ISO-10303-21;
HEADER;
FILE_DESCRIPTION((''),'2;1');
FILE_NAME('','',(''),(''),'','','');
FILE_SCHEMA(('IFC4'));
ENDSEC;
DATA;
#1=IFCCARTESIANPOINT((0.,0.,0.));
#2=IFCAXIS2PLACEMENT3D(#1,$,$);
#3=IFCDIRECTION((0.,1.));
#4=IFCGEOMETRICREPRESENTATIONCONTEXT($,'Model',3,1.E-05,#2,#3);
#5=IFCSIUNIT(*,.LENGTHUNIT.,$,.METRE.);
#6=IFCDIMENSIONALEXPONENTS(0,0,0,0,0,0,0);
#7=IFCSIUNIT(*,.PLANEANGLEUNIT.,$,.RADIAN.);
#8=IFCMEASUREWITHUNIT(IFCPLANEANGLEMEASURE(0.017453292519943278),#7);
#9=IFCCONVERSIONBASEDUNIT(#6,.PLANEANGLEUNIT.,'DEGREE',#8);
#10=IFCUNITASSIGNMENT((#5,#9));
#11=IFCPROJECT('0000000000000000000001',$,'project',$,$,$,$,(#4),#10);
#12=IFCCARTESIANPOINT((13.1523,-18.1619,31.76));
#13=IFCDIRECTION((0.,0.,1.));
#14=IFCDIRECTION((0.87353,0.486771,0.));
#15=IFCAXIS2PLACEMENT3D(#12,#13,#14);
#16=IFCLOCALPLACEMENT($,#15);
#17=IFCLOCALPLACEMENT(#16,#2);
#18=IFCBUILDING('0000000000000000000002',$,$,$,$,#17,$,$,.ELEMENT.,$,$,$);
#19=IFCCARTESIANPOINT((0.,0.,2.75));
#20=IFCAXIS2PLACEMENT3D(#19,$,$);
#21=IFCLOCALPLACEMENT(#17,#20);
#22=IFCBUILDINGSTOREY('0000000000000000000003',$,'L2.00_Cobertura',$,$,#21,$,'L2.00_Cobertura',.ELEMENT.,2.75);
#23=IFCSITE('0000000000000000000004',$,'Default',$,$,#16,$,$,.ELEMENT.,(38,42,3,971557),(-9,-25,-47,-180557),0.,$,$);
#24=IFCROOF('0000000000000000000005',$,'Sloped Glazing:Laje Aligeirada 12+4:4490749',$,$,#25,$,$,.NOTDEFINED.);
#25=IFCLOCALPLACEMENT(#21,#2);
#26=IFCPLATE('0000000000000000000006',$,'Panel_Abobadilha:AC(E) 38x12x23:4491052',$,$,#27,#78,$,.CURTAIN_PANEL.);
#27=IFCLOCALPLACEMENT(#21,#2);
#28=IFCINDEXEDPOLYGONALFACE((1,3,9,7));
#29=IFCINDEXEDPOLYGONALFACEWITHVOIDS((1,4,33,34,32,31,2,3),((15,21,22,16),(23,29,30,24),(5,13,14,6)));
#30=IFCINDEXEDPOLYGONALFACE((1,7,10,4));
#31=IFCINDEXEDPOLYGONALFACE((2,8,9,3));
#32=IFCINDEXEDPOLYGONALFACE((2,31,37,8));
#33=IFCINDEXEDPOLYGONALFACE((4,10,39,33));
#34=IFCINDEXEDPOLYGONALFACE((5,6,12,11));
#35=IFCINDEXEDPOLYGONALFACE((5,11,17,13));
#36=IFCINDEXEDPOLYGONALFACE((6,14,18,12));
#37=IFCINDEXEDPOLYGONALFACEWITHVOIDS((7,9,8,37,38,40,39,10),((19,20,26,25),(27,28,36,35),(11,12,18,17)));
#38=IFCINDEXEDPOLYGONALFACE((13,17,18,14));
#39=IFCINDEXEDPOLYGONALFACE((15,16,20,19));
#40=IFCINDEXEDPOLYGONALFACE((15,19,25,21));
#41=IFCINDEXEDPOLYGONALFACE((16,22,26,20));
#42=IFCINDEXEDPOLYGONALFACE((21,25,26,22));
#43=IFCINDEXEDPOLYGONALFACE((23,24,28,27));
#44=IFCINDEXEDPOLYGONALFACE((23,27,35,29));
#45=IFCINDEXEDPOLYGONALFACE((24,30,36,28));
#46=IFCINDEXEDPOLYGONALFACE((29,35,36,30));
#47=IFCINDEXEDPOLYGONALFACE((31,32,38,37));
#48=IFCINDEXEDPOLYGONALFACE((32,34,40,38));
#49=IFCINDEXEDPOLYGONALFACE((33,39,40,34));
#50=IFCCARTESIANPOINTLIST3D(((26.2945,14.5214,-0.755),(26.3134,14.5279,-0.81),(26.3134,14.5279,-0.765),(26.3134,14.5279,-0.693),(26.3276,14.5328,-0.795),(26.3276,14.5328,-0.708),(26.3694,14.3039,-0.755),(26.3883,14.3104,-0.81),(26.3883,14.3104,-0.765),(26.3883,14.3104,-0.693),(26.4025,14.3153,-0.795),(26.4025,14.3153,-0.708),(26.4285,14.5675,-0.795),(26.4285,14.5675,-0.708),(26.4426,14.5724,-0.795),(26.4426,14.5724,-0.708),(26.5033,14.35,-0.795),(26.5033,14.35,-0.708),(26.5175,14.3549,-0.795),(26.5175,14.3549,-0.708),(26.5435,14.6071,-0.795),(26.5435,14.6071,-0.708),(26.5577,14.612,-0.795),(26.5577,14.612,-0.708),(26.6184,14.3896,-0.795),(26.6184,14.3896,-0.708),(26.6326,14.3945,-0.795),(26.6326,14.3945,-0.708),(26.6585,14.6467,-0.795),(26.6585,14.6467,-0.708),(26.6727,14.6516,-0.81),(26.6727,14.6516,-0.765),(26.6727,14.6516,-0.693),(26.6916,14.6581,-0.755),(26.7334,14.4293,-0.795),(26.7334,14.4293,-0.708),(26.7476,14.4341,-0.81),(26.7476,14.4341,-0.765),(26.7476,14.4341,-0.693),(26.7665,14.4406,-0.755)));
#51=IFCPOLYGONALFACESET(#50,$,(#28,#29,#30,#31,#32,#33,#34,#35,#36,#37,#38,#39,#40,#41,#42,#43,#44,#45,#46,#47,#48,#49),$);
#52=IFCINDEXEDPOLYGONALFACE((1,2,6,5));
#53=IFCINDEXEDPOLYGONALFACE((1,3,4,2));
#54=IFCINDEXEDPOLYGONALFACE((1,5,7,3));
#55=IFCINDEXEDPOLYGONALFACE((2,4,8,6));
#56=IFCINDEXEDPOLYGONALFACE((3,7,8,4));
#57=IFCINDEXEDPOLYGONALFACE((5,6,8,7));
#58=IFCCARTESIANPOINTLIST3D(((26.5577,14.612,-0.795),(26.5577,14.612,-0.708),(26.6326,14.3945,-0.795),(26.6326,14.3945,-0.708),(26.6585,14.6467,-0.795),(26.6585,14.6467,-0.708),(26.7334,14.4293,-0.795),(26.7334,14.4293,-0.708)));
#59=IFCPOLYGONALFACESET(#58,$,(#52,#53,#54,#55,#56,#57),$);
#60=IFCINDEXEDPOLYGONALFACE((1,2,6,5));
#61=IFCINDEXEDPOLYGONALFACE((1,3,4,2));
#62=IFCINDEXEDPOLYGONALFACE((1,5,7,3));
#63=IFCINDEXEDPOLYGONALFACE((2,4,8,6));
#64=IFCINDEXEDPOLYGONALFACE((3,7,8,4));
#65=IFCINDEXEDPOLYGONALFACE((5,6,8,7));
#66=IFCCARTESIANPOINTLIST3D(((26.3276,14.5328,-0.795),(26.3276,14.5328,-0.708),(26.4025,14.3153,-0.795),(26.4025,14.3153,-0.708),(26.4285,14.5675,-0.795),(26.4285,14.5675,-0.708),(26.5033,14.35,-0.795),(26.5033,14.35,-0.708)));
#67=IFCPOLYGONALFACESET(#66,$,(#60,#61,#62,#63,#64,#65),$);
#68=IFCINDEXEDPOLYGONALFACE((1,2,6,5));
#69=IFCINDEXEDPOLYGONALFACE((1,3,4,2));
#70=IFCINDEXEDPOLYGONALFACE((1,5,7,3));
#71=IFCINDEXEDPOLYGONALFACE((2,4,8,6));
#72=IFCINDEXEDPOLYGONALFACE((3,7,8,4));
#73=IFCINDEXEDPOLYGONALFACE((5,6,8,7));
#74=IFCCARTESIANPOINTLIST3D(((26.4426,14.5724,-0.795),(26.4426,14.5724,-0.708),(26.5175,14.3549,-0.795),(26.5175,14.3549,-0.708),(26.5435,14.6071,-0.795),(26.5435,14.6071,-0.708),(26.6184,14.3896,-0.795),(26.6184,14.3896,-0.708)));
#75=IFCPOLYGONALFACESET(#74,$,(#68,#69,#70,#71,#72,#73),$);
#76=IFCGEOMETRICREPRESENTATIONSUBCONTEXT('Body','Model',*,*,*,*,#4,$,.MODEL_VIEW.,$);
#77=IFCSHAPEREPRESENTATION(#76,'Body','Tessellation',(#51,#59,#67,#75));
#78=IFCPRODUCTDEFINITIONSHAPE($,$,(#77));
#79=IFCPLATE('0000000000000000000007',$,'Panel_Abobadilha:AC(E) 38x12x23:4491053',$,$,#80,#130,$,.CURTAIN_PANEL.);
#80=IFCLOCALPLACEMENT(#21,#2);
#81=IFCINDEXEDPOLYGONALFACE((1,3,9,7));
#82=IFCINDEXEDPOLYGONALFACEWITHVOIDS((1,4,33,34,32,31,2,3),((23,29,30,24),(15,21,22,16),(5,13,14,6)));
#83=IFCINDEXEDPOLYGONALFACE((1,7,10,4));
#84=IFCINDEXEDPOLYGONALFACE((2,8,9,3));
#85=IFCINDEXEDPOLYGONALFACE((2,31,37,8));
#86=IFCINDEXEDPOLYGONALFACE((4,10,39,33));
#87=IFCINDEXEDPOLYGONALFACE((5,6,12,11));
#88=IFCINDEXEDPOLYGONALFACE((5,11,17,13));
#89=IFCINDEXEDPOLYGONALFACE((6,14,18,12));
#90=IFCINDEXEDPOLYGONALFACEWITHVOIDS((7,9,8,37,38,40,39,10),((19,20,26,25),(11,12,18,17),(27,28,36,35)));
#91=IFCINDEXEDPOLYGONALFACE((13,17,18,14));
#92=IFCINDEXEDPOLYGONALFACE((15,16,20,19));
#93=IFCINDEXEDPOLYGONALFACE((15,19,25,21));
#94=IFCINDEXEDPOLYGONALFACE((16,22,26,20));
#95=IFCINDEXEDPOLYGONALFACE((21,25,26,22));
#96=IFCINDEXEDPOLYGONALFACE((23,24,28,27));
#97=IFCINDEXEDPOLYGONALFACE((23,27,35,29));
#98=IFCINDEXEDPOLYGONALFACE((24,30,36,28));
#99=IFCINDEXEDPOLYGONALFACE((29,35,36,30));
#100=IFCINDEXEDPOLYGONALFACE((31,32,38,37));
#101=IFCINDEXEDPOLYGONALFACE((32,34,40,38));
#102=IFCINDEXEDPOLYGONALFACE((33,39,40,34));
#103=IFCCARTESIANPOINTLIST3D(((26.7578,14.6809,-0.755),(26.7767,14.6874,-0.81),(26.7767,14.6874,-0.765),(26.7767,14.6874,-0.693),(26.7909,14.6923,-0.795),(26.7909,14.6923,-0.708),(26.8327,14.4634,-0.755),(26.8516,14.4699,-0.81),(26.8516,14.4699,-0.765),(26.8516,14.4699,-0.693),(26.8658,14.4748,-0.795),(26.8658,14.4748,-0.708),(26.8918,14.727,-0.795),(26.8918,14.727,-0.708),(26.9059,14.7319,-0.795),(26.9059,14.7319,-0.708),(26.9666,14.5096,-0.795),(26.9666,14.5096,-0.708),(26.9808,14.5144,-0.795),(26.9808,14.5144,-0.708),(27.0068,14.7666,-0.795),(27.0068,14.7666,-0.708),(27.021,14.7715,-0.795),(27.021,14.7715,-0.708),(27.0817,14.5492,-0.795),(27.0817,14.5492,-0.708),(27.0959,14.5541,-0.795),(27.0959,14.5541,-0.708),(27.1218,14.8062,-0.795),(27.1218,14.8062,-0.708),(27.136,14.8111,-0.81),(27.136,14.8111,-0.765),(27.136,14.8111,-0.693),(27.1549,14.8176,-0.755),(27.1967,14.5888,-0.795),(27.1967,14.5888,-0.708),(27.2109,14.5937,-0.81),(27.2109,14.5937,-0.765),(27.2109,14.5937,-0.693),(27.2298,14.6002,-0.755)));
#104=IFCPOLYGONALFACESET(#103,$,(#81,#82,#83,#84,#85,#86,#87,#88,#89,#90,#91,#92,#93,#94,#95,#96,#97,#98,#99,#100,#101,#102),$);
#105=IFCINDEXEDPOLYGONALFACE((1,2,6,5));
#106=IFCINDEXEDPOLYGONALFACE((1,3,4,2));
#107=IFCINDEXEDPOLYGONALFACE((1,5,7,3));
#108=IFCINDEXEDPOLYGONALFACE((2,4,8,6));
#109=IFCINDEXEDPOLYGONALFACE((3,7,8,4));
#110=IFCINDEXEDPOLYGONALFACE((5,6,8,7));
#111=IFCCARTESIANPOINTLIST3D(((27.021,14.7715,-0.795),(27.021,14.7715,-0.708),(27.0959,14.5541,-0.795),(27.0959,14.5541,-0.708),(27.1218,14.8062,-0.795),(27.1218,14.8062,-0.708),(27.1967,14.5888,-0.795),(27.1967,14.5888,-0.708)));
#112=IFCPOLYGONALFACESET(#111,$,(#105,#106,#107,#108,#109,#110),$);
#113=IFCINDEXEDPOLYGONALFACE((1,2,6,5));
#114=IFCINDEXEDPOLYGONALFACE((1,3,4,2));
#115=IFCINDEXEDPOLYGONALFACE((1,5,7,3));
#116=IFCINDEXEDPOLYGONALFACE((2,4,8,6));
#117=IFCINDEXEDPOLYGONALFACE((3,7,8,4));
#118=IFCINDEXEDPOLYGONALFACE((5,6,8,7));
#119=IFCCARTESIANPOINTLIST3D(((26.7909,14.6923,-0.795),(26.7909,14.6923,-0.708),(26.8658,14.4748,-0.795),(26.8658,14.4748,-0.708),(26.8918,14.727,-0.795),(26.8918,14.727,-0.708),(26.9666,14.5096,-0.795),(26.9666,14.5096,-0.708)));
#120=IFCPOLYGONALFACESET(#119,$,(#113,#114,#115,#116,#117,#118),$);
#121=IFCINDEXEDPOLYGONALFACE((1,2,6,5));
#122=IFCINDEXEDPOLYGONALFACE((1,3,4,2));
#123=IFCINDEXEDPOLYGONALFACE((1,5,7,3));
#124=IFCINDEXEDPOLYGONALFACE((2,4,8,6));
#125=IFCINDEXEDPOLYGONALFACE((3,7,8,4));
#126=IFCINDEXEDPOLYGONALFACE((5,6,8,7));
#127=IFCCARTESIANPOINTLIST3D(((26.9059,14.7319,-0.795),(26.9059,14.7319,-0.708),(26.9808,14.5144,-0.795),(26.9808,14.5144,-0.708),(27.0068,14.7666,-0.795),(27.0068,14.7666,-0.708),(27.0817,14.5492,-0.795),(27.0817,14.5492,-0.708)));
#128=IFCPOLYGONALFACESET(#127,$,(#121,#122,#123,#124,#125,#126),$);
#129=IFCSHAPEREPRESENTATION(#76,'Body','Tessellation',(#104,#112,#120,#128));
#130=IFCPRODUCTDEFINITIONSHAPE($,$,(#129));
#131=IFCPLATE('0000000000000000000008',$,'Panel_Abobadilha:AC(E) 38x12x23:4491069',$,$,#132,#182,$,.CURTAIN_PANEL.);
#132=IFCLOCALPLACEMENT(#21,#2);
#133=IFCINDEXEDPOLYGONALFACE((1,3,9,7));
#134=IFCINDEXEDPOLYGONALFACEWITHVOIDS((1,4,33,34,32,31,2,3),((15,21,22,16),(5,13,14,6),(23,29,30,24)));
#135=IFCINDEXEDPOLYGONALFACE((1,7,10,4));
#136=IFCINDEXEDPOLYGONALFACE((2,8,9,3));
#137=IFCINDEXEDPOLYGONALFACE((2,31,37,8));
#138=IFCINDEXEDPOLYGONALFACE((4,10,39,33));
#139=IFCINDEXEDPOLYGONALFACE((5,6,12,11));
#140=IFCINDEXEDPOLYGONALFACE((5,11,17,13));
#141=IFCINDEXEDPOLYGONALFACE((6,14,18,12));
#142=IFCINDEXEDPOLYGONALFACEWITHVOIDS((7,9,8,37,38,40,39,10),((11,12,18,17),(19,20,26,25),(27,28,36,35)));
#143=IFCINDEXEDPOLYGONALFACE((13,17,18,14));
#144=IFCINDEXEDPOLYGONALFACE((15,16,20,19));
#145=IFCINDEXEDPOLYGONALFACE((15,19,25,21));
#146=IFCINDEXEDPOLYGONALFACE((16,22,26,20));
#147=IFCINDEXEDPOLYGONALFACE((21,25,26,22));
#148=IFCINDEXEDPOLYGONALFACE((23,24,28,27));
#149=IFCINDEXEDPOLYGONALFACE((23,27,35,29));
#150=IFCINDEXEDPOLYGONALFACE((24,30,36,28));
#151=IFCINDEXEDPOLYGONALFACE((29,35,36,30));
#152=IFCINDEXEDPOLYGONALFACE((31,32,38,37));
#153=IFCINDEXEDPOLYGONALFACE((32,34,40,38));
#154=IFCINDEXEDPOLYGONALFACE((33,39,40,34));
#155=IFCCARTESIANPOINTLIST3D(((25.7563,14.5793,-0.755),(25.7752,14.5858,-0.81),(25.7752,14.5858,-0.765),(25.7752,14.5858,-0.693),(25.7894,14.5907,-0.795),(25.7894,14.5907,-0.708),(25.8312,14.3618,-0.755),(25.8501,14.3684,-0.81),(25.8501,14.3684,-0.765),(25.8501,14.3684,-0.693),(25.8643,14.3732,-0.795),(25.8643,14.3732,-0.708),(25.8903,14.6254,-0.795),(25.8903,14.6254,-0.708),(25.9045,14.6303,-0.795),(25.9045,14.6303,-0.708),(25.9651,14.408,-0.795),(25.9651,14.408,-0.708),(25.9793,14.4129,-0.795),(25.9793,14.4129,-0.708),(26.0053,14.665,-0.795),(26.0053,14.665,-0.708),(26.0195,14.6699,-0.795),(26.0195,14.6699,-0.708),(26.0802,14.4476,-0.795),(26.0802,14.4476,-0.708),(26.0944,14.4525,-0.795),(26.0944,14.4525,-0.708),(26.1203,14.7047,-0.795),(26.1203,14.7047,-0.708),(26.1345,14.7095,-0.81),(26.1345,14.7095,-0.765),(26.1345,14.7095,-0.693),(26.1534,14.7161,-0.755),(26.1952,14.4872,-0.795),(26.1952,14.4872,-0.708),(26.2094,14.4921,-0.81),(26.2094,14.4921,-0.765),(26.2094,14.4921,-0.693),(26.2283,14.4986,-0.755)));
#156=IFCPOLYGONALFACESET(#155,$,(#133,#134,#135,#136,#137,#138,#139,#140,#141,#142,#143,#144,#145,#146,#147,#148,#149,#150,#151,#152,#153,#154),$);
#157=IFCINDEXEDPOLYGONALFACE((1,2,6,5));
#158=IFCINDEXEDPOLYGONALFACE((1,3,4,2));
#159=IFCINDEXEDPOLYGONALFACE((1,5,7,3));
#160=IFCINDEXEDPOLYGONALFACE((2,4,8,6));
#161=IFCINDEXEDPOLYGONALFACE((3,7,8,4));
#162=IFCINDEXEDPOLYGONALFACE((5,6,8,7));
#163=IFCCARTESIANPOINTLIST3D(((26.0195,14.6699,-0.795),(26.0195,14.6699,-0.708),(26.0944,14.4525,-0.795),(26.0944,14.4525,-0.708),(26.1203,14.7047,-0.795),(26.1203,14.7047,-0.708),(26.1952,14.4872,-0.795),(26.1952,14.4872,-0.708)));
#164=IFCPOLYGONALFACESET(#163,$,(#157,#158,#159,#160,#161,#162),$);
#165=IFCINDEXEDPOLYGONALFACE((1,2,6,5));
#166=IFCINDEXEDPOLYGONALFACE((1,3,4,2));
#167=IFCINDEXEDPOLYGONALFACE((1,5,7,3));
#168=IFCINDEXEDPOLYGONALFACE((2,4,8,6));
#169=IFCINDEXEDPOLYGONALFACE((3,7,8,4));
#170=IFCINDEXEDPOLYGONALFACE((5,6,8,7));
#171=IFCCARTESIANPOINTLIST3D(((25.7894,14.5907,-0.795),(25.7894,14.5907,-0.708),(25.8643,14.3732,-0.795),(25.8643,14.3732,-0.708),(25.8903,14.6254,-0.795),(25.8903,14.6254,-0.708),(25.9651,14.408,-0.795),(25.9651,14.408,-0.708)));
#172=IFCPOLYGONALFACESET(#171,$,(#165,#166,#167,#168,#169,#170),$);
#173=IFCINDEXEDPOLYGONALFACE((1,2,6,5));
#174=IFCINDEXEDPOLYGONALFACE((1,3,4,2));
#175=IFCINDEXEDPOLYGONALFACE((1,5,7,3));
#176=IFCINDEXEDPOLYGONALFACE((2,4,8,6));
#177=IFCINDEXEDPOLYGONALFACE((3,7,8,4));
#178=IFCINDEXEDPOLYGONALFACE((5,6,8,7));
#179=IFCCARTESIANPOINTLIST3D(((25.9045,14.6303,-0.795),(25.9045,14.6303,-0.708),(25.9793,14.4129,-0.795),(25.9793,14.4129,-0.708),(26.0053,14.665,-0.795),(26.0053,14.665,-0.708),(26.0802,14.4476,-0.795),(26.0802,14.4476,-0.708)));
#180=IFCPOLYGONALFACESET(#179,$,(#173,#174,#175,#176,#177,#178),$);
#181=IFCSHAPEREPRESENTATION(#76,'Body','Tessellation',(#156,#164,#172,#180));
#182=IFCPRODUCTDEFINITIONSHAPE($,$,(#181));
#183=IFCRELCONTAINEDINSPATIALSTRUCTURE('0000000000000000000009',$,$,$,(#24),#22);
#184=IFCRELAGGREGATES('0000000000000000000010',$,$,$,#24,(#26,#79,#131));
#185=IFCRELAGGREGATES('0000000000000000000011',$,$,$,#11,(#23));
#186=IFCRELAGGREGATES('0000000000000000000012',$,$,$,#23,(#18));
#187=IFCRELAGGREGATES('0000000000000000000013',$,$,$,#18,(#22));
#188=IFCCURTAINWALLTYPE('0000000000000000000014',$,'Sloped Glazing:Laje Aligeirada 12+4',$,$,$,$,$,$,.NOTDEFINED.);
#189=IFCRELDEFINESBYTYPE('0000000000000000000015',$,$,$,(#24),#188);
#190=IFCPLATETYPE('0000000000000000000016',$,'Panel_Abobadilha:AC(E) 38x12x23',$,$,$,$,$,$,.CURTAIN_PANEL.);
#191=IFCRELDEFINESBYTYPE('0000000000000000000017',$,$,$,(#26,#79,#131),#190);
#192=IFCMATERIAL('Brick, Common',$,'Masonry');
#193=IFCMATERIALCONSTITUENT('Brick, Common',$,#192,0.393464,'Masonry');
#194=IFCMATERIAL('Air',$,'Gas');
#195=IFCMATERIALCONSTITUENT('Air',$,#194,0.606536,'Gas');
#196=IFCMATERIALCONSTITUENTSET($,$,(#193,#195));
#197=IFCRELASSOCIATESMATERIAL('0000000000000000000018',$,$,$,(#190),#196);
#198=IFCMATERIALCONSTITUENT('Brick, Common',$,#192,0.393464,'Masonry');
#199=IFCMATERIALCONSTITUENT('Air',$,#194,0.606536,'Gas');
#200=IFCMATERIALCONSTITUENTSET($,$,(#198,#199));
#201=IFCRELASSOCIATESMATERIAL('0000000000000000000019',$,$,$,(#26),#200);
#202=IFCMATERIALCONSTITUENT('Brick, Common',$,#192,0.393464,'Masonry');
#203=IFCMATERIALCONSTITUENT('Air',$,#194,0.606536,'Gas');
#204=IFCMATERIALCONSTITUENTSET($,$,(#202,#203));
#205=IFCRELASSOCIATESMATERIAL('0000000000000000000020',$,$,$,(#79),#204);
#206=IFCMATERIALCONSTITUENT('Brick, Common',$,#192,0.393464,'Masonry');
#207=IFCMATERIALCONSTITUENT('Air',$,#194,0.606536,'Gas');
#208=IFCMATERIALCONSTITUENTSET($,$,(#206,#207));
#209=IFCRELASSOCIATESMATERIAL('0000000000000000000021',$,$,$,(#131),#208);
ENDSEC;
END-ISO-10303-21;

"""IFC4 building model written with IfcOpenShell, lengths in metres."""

from ifc_helpers import new_model, entity, si_unit, converted_unit, direction, frame, origin, place, context, subcontext, project, spatial, indexed_curve, outline, extrude, source, transform, mapped, material, constituent, constituent_set, type_object, type_shapes, element, aggregate, save


model = new_model("IFC4")

# Units and contexts
model_context = context("Model", 3, precision=1e-05, world=origin(), true_north=direction((0.0, 1.0)))
body_context = subcontext(model_context, "Body", "Model", "MODEL_VIEW")
ifc_project = project(units=[si_unit("LENGTHUNIT", "METRE"), converted_unit("PLANEANGLEUNIT", "DEGREE", entity("IfcPlaneAngleMeasure", 0.017453292519943278), si_unit("PLANEANGLEUNIT", "RADIAN"), dimensions=[0, 0, 0, 0, 0, 0, 0])], contexts=[model_context])

# Site, building, storey
site_placement = place(None, frame((13.1523, -18.1619, 31.76), z_axis=(0.0, 0.0, 1.0), x_axis=(0.87353, 0.486771, 0.0)))
site = spatial("IfcSite", under=ifc_project, at=site_placement, Name="Default", CompositionType="ELEMENT", RefLatitude=(38, 42, 3, 971557), RefLongitude=(-9, -25, -47, -180557), RefElevation=0.0)
building_placement = place(site_placement, origin())
building = spatial("IfcBuilding", under=site, at=building_placement, CompositionType="ELEMENT")
storey_placement = place(building_placement, frame((0.0, 0.0, 2.75)))
storey = spatial("IfcBuildingStorey", under=building, at=storey_placement, Name="L2.00_Cobertura", LongName="L2.00_Cobertura", CompositionType="ELEMENT", Elevation=2.75)

# Roof, plates
curtain_wall_type = type_object("IfcCurtainWallType", Name="Sloped Glazing:Laje Aligeirada 12+4", PredefinedType="NOTDEFINED")
roof_placement = place(storey_placement, frame((0.0, 0.0, -2.75)))
roof = element("IfcRoof", 1, at=roof_placement, inside=storey, type_object=curtain_wall_type, Name="Sloped Glazing:Laje Aligeirada 12+4:4490749", PredefinedType="NOTDEFINED")
ifc_material_1 = material(Name="Brick, Common", Category="Masonry")
ifc_material_2 = material(Name="Air", Category="Gas")
ifc_constituent_1 = constituent(ifc_material_1, Name="Brick, Common", Category="Masonry", fraction=0.393464)
ifc_constituent_2 = constituent(ifc_material_2, Name="Air", Category="Gas", fraction=0.606536)
ifc_constituent_set_1 = constituent_set(constituents=[ifc_constituent_1, ifc_constituent_2])
plate_type = type_object("IfcPlateType", Name="Panel_Abobadilha:AC(E) 38x12x23", PredefinedType="CURTAIN_PANEL", material=ifc_constituent_set_1)
shared_shape_1 = source(origin(), body_context, "Body", "SweptSolid", [
    extrude(outline(indexed_curve([(-0.19, -0.0543), (0.19, -0.0543), (0.19, -0.0093), (0.21, 0.0007), (0.19, 0.0628), (-0.19, 0.0628), (-0.21, 0.0007), (-0.19, -0.0093), (-0.19, -0.0543)], self_intersect=False), holes=[indexed_curve([(-0.0683, 0.0477), (-0.0683, -0.0393), (-0.175, -0.0393), (-0.175, 0.0477), (-0.0683, 0.0477)], self_intersect=False), indexed_curve([(0.0533, 0.0477), (0.0533, -0.0393), (-0.0533, -0.0393), (-0.0533, 0.0477), (0.0533, 0.0477)], self_intersect=False), indexed_curve([(0.175, 0.0477), (0.175, -0.0393), (0.0683, -0.0393), (0.0683, 0.0477), (0.175, 0.0477)], self_intersect=False)]), frame((0.0, 0.0543, 0.0)), (0.0, 0.0, 1.0), 0.23),
    extrude(outline(indexed_curve([(-0.0533, -0.0435), (0.0533, -0.0435), (0.0533, 0.0435), (-0.0533, 0.0435), (-0.0533, -0.0435)], self_intersect=False)), frame((0.1217, 0.0585, 0.0), z_axis=(0.0, 0.0, 1.0), x_axis=(-1.0, 0.0, 0.0)), (0.0, 0.0, 1.0), 0.23),
    extrude(outline(indexed_curve([(-0.0533, -0.0435), (0.0533, -0.0435), (0.0533, 0.0435), (-0.0533, 0.0435), (-0.0533, -0.0435)], self_intersect=False)), frame((-0.1217, 0.0585, 0.0), z_axis=(0.0, 0.0, 1.0), x_axis=(-1.0, 0.0, 0.0)), (0.0, 0.0, 1.0), 0.23),
    extrude(outline(indexed_curve([(-0.0533, -0.0435), (0.0533, -0.0435), (0.0533, 0.0435), (-0.0533, 0.0435), (-0.0533, -0.0435)], self_intersect=False)), frame((0.0, 0.0585, 0.0), z_axis=(0.0, 0.0, 1.0), x_axis=(-1.0, 0.0, 0.0)), (0.0, 0.0, 1.0), 0.23),
])
type_shapes(plate_type, [shared_shape_1])
ifc_constituent_3 = constituent(ifc_material_1, Name="Brick, Common", Category="Masonry", fraction=0.393464)
ifc_constituent_4 = constituent(ifc_material_2, Name="Air", Category="Gas", fraction=0.606536)
ifc_constituent_set_2 = constituent_set(constituents=[ifc_constituent_3, ifc_constituent_4])
plate_1_placement = place(roof_placement, frame((26.4931, 14.5897, 1.94), z_axis=(0.325568, -0.945519, 0.0), x_axis=(0.945519, 0.325568, 0.0)))
plate_1 = element("IfcPlate", 2, at=plate_1_placement, type_object=plate_type, material=ifc_constituent_set_2, Name="Panel_Abobadilha:AC(E) 38x12x23:4491052", PredefinedType="CURTAIN_PANEL", context=body_context, shape_type="MappedRepresentation", body=[
    mapped(shared_shape_1, transform((0.0, 0.0, 0.0), scale=1.0)),
])
ifc_constituent_5 = constituent(ifc_material_1, Name="Brick, Common", Category="Masonry", fraction=0.393464)
ifc_constituent_6 = constituent(ifc_material_2, Name="Air", Category="Gas", fraction=0.606536)
ifc_constituent_set_3 = constituent_set(constituents=[ifc_constituent_5, ifc_constituent_6])
plate_2_placement = place(roof_placement, frame((26.9564, 14.7493, 1.94), z_axis=(0.325568, -0.945519, 0.0), x_axis=(0.945519, 0.325568, 0.0)))
plate_2 = element("IfcPlate", 3, at=plate_2_placement, type_object=plate_type, material=ifc_constituent_set_3, Name="Panel_Abobadilha:AC(E) 38x12x23:4491053", PredefinedType="CURTAIN_PANEL", context=body_context, shape_type="MappedRepresentation", body=[
    mapped(shared_shape_1, transform((0.0, 0.0, 0.0), scale=1.0)),
])
ifc_constituent_7 = constituent(ifc_material_1, Name="Brick, Common", Category="Masonry", fraction=0.393464)
ifc_constituent_8 = constituent(ifc_material_2, Name="Air", Category="Gas", fraction=0.606536)
ifc_constituent_set_4 = constituent_set(constituents=[ifc_constituent_7, ifc_constituent_8])
plate_3_placement = place(roof_placement, frame((25.9549, 14.6477, 1.94), z_axis=(0.325568, -0.945519, 0.0), x_axis=(0.945519, 0.325568, 0.0)))
plate_3 = element("IfcPlate", 4, at=plate_3_placement, type_object=plate_type, material=ifc_constituent_set_4, Name="Panel_Abobadilha:AC(E) 38x12x23:4491069", PredefinedType="CURTAIN_PANEL", context=body_context, shape_type="MappedRepresentation", body=[
    mapped(shared_shape_1, transform((0.0, 0.0, 0.0), scale=1.0)),
])
aggregate(roof, [plate_1, plate_2, plate_3])

save(model, "model.ifc")
